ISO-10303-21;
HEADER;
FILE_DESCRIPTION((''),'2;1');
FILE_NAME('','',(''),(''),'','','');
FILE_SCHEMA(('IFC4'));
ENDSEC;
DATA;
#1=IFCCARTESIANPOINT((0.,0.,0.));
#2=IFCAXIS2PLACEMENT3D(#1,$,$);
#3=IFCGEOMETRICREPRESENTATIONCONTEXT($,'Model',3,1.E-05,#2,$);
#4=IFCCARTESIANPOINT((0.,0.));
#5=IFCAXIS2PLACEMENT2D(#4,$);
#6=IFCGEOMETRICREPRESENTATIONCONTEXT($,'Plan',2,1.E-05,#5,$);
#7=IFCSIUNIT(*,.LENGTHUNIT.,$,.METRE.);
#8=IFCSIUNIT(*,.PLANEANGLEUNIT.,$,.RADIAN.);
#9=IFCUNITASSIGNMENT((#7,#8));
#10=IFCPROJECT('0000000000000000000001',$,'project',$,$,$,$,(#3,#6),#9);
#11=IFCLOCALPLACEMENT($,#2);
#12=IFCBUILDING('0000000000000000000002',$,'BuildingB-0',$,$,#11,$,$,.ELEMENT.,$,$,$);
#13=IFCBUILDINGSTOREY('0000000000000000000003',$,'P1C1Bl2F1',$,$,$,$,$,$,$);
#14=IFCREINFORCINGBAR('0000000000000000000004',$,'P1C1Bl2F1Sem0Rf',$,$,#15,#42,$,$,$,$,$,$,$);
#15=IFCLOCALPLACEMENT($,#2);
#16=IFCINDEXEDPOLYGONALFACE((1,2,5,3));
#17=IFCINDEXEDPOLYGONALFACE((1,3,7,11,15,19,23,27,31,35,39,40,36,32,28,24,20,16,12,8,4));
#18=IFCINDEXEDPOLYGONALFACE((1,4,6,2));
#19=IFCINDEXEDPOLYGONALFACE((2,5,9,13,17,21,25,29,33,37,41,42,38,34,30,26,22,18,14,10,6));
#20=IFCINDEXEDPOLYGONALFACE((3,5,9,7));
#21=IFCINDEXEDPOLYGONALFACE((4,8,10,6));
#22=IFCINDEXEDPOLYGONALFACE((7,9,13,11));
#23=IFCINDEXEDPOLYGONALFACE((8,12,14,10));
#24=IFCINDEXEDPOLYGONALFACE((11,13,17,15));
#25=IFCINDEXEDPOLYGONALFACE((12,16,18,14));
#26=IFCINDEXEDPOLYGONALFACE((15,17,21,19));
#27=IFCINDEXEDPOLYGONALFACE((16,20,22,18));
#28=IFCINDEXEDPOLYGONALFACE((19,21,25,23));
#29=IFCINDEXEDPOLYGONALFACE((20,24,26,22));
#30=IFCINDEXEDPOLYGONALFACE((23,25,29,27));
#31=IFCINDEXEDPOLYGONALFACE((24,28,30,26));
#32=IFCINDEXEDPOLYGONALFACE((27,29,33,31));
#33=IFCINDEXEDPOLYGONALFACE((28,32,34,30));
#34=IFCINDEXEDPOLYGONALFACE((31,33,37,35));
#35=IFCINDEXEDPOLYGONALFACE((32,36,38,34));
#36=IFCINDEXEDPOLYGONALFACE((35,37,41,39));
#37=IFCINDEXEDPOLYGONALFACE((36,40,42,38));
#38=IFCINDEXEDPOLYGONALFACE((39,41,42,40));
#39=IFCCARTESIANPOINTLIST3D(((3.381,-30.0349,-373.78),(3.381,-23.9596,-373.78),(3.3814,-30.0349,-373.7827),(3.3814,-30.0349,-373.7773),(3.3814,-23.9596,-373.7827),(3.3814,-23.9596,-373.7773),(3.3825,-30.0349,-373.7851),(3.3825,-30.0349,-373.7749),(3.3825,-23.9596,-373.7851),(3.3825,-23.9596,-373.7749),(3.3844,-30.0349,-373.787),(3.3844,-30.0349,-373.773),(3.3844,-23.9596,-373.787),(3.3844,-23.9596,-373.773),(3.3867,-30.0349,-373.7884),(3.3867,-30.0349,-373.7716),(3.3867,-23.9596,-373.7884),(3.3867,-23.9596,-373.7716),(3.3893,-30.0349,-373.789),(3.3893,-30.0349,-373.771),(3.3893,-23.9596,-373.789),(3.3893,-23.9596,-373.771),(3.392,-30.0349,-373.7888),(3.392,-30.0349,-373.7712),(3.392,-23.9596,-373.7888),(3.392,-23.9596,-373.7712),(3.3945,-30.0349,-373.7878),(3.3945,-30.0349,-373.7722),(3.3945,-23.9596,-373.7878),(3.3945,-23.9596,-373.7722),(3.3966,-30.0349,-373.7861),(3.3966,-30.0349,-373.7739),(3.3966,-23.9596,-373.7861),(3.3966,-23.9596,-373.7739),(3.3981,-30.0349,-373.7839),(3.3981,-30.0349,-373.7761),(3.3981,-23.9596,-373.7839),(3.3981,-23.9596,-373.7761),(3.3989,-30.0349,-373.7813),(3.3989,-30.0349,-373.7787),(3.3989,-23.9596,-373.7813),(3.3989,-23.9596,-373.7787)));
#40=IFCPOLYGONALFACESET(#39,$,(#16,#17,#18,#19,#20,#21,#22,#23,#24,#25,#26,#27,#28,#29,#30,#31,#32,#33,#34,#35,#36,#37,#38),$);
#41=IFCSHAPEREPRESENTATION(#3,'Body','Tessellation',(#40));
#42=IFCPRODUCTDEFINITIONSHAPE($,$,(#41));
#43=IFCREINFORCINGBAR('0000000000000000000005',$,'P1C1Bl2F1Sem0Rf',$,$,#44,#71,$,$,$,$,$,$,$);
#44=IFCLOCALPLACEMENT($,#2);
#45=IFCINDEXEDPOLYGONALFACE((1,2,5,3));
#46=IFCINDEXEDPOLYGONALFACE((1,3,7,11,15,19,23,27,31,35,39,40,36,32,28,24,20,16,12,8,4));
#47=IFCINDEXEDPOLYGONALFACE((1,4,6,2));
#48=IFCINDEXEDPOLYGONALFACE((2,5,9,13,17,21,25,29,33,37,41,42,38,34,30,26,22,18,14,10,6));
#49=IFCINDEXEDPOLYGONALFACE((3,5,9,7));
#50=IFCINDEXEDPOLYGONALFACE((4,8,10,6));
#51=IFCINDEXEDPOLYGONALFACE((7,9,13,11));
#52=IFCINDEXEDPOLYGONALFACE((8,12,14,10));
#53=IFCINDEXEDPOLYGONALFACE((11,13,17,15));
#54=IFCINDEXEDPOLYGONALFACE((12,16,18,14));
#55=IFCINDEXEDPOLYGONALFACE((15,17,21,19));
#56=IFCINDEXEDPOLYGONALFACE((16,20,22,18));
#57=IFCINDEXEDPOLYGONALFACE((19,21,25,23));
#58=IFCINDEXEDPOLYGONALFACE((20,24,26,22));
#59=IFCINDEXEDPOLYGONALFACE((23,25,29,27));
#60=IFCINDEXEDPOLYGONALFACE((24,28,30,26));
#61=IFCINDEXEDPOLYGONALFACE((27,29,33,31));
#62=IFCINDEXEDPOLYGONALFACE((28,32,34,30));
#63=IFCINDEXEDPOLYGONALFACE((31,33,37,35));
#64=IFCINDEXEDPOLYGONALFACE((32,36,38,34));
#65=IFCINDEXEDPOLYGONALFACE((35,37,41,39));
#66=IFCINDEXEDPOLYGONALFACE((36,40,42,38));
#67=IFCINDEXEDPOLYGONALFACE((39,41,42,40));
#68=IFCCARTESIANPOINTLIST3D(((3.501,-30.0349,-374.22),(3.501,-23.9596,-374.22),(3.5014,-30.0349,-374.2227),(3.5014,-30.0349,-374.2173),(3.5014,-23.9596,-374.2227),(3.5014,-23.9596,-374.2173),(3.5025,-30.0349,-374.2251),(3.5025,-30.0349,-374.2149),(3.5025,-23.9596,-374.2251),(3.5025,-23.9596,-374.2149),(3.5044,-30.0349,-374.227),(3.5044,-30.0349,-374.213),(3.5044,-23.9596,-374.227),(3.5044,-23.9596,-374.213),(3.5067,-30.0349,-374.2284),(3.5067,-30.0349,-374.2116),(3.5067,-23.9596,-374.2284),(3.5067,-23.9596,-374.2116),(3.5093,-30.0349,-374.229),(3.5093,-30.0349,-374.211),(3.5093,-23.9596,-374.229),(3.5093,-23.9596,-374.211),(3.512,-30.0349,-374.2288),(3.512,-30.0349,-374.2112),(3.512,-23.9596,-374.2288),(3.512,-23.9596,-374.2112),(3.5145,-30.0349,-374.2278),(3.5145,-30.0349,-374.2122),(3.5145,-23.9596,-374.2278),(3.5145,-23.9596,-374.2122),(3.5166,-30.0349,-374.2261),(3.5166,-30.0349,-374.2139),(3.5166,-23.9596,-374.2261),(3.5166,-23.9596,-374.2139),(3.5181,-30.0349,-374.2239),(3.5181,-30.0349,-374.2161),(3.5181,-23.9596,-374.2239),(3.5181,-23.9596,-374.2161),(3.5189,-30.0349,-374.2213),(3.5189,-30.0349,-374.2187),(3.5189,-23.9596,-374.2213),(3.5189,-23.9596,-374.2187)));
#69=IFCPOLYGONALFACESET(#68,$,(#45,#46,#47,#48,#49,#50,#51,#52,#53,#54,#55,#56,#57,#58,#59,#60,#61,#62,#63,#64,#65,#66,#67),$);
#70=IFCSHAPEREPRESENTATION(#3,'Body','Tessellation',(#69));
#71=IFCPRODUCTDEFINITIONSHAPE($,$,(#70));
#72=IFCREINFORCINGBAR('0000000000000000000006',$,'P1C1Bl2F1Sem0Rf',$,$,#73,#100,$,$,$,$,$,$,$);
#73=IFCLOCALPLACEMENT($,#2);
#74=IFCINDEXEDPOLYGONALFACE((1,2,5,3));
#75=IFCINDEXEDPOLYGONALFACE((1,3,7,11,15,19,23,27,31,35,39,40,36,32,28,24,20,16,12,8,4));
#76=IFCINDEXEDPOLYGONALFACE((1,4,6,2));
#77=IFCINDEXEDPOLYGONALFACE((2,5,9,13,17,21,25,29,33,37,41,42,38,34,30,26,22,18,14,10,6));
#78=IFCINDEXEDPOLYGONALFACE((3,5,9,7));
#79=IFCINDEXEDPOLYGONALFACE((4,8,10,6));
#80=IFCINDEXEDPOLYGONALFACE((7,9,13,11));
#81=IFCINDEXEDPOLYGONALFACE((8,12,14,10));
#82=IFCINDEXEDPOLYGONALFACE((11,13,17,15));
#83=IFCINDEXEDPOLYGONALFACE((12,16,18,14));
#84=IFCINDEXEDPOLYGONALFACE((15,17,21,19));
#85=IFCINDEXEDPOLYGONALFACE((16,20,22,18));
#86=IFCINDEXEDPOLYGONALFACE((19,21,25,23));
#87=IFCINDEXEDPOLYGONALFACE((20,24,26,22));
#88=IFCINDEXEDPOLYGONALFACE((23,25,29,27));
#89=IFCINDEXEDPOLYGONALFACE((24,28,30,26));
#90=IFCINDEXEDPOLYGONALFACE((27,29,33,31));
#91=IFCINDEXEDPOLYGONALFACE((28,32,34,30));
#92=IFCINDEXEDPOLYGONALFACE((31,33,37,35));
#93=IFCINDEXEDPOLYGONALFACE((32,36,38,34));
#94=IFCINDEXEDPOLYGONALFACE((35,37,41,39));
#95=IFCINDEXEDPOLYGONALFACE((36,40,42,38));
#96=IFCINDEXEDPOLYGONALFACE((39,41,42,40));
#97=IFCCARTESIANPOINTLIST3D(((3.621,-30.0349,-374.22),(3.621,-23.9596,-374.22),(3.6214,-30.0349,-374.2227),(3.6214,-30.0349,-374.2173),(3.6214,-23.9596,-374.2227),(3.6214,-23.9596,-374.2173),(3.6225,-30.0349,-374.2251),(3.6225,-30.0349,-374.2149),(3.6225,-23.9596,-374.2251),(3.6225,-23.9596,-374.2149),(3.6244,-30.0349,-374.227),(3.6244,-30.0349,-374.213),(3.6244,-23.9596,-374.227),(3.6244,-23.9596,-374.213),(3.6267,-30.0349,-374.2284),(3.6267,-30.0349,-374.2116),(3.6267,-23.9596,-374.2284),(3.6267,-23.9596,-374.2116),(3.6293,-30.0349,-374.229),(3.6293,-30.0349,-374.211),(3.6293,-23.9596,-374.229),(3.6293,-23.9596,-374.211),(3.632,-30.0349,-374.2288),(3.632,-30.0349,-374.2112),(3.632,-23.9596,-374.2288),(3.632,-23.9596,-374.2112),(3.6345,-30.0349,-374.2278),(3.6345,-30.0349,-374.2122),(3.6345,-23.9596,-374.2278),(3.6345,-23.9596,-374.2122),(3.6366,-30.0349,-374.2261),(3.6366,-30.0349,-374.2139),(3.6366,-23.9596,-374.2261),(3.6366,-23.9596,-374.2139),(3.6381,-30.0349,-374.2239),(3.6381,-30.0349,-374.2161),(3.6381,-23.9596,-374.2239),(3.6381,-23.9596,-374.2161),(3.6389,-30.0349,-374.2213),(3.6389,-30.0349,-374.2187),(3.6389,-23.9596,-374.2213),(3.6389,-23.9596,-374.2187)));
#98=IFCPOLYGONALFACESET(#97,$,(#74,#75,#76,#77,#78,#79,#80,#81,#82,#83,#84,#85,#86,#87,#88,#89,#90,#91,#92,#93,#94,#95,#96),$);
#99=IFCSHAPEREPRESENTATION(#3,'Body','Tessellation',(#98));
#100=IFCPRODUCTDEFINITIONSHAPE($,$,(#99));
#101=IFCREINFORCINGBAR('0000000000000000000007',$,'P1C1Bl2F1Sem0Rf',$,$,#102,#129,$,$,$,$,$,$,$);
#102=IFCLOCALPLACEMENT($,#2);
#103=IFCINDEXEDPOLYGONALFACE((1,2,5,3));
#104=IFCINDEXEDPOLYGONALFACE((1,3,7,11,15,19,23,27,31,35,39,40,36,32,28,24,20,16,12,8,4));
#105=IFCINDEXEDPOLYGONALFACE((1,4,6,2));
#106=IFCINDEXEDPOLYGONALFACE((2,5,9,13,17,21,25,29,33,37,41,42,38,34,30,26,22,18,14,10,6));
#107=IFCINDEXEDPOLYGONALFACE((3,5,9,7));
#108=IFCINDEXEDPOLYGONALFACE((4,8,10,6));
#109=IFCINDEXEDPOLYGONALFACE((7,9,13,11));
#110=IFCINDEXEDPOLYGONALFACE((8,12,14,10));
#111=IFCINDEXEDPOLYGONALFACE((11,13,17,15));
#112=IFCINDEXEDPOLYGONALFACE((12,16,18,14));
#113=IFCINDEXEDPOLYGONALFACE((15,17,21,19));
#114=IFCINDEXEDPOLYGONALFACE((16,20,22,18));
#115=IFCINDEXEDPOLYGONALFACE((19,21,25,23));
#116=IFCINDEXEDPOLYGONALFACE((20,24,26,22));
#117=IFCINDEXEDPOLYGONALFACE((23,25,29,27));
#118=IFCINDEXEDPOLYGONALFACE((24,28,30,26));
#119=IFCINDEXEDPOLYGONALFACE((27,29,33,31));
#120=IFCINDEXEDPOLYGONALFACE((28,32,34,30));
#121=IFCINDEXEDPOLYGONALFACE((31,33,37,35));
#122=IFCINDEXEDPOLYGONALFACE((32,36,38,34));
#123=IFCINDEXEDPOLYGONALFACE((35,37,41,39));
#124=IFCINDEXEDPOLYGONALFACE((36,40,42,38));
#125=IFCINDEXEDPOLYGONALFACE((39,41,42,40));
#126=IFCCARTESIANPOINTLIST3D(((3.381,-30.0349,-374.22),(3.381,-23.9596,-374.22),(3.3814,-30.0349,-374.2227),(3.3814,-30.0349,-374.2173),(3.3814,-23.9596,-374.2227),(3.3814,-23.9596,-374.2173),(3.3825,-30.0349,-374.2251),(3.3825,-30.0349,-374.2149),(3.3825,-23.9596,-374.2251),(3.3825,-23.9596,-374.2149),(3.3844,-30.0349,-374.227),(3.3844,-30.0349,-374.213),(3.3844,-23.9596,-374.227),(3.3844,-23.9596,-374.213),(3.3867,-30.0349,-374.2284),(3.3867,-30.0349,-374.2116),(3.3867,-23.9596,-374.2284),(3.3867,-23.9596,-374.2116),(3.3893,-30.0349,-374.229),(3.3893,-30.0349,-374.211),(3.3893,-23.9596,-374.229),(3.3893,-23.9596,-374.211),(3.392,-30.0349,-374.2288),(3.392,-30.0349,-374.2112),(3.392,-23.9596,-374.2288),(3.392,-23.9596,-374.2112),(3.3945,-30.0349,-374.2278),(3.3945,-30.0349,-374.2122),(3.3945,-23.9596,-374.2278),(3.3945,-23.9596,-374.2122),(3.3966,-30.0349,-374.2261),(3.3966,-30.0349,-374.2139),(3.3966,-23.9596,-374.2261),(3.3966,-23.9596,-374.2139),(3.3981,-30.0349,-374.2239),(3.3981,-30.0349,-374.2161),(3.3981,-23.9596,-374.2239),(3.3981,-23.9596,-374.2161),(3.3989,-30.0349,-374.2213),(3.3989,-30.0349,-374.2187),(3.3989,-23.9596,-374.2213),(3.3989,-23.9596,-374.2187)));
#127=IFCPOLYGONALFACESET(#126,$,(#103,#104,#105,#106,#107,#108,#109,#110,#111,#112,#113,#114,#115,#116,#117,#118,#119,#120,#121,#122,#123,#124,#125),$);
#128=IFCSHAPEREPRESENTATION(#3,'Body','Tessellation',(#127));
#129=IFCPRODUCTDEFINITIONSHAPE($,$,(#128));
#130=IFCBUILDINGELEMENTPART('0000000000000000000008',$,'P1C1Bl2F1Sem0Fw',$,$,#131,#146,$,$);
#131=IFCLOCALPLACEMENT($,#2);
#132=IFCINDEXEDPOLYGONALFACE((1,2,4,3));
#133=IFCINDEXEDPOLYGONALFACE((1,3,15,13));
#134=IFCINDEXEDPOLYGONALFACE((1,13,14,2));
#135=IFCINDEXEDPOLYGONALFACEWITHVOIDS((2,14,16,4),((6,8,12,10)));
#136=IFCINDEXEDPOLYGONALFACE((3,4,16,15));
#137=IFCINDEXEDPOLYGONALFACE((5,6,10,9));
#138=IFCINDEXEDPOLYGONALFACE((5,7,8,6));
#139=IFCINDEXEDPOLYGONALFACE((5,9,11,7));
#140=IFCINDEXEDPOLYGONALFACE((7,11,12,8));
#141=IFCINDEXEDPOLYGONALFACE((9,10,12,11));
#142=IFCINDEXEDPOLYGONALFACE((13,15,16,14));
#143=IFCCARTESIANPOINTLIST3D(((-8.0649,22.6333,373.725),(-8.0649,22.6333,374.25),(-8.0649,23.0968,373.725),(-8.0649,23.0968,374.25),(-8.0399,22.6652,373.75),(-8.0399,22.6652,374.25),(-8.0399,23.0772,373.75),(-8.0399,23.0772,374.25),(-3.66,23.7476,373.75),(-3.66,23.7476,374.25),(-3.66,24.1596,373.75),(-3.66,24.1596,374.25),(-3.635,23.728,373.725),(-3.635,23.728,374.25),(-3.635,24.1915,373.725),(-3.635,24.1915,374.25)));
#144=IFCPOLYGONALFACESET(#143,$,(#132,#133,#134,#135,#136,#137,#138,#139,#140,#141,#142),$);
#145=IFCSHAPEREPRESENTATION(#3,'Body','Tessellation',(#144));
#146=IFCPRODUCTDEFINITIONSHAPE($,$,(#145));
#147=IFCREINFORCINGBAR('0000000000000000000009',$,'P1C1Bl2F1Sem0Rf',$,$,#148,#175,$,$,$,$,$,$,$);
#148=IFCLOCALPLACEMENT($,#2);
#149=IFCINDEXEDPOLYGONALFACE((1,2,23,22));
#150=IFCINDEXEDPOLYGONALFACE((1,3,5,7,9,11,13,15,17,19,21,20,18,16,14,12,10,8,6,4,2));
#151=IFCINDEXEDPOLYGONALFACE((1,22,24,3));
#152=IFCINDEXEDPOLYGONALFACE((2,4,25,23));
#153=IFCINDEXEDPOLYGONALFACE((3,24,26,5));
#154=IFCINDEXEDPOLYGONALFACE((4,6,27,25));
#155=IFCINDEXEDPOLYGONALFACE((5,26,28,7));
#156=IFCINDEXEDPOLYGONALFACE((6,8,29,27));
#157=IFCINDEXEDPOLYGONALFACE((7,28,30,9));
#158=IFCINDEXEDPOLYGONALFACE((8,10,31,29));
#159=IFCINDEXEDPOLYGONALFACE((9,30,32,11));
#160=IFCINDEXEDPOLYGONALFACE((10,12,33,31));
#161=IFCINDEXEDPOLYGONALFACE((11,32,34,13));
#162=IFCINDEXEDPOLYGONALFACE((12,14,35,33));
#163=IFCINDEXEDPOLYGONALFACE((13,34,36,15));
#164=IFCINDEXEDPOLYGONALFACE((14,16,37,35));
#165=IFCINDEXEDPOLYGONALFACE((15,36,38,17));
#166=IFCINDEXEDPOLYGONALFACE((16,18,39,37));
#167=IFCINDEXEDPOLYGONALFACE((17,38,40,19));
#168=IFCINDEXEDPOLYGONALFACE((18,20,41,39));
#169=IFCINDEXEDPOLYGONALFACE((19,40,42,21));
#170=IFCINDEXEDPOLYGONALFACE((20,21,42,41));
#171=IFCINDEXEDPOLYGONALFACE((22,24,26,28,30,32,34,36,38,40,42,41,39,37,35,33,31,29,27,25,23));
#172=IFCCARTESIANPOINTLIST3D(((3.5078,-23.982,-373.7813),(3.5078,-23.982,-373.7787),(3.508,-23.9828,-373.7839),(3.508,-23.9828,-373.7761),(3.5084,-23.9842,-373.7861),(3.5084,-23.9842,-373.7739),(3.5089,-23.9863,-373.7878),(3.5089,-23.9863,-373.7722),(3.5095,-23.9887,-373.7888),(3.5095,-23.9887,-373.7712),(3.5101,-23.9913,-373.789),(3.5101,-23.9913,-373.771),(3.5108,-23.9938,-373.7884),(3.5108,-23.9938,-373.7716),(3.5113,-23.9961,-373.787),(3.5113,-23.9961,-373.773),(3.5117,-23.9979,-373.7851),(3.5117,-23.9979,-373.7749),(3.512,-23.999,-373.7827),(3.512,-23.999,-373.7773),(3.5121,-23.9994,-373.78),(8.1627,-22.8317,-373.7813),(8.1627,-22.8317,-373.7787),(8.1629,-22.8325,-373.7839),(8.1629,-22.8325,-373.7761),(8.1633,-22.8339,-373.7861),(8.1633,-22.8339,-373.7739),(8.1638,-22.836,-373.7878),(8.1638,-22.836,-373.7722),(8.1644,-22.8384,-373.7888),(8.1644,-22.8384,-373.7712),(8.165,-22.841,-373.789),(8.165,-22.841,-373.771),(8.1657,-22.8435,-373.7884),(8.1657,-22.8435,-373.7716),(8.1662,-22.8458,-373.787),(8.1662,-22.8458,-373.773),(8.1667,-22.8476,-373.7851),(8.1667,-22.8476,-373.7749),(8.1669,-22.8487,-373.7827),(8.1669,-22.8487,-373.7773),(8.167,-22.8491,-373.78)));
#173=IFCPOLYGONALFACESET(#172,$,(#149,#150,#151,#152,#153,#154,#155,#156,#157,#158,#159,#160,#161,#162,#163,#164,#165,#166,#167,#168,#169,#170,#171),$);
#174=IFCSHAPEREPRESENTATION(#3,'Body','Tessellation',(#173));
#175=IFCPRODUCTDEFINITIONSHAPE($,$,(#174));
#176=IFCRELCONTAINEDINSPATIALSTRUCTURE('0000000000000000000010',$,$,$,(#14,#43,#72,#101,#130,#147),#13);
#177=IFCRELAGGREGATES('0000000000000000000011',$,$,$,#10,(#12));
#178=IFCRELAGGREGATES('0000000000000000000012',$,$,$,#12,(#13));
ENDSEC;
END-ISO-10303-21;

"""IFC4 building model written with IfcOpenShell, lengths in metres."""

from ifc_helpers import new_model, entity, si_unit, origin, origin_2d, place, context, project, spatial, polyline, outline, extrude, element, save


model = new_model("IFC4")

# Units and contexts
model_context = context("Model", 3, precision=1e-05, world=origin())
plan_context = context("Plan", 2, precision=1e-05, world=origin_2d())
ifc_project = project(units=[si_unit("LENGTHUNIT", "METRE"), si_unit("PLANEANGLEUNIT", "RADIAN")], contexts=[model_context, plan_context])

# Building, storey
building_placement = place(None, origin())
building = spatial("IfcBuilding", under=ifc_project, at=building_placement, Name="BuildingB-0", CompositionType="ELEMENT")
storey = spatial("IfcBuildingStorey", under=building, Name="P1C1Bl2F1")

# Reinforcing bars
element("IfcReinforcingBar", 1, inside=storey, Name="P1C1Bl2F1Sem0Rf", context=model_context, shape_type="SweptSolid", body=[
    entity("IfcSurfaceCurveSweptAreaSolid", entity("IfcCircleProfileDef", "AREA", None, None, 0.009), None, entity("IfcPolyline", [entity("IfcCartesianPoint", [-3.39, 30.0349, 373.78]), entity("IfcCartesianPoint", [-3.39, 23.9596, 373.78])]), None, None, entity("IfcPlane", entity("IfcAxis2Placement3D", entity("IfcCartesianPoint", [-3.39, 30.0349, 373.78]), entity("IfcDirection", [0.0, 0.0, 1.0]), entity("IfcDirection", [1.0, 0.0, 0.0])))),
])
element("IfcReinforcingBar", 2, inside=storey, Name="P1C1Bl2F1Sem0Rf", context=model_context, shape_type="SweptSolid", body=[
    entity("IfcSurfaceCurveSweptAreaSolid", entity("IfcCircleProfileDef", "AREA", None, None, 0.009), None, entity("IfcPolyline", [entity("IfcCartesianPoint", [-3.51, 30.0349, 374.22]), entity("IfcCartesianPoint", [-3.51, 23.9596, 374.22])]), None, None, entity("IfcPlane", entity("IfcAxis2Placement3D", entity("IfcCartesianPoint", [-3.51, 30.0349, 374.22]), entity("IfcDirection", [0.0, 0.0, 1.0]), entity("IfcDirection", [1.0, 0.0, 0.0])))),
])
element("IfcReinforcingBar", 3, inside=storey, Name="P1C1Bl2F1Sem0Rf", context=model_context, shape_type="SweptSolid", body=[
    entity("IfcSurfaceCurveSweptAreaSolid", entity("IfcCircleProfileDef", "AREA", None, None, 0.009), None, entity("IfcPolyline", [entity("IfcCartesianPoint", [-3.63, 30.0349, 374.22]), entity("IfcCartesianPoint", [-3.63, 23.9596, 374.22])]), None, None, entity("IfcPlane", entity("IfcAxis2Placement3D", entity("IfcCartesianPoint", [-3.63, 30.0349, 374.22]), entity("IfcDirection", [0.0, 0.0, 1.0]), entity("IfcDirection", [1.0, 0.0, 0.0])))),
])
element("IfcReinforcingBar", 4, inside=storey, Name="P1C1Bl2F1Sem0Rf", context=model_context, shape_type="SweptSolid", body=[
    entity("IfcSurfaceCurveSweptAreaSolid", entity("IfcCircleProfileDef", "AREA", None, None, 0.009), None, entity("IfcPolyline", [entity("IfcCartesianPoint", [-3.39, 30.0349, 374.22]), entity("IfcCartesianPoint", [-3.39, 23.9596, 374.22])]), None, None, entity("IfcPlane", entity("IfcAxis2Placement3D", entity("IfcCartesianPoint", [-3.39, 30.0349, 374.22]), entity("IfcDirection", [0.0, 0.0, 1.0]), entity("IfcDirection", [1.0, 0.0, 0.0])))),
])

# Building element part, opening
building_element_part_1 = element("IfcBuildingElementPart", 5, inside=storey, Name="P1C1Bl2F1Sem0Fw", context=model_context, shape_type="SweptSolid", body=[
    extrude(outline(polyline([(-3.635, 24.1915, 373.725), (-3.635, 23.728, 373.725), (-8.0649, 22.6333, 373.725), (-8.0649, 23.0968, 373.725), (-3.635, 24.1915, 373.725)])), None, (0.0, 0.0, 1.0), 0.525),
])
element("IfcOpeningElement", 6, inside=storey, cuts=building_element_part_1, context=model_context, shape_type="SweptSolid", body=[
    extrude(outline(polyline([(-3.66, 24.1596, 373.75), (-3.66, 23.7476, 373.75), (-8.0399, 22.6652, 373.75), (-8.0399, 23.0772, 373.75), (-3.66, 24.1596, 373.75)])), None, (0.0, 0.0, 1.0), 0.5),
])

# Reinforcing bar
element("IfcReinforcingBar", 7, inside=storey, Name="P1C1Bl2F1Sem0Rf", context=model_context, shape_type="SweptSolid", body=[
    entity("IfcSurfaceCurveSweptAreaSolid", entity("IfcCircleProfileDef", "AREA", None, None, 0.009), None, entity("IfcPolyline", [entity("IfcCartesianPoint", [-3.51, 23.9907, 373.78]), entity("IfcCartesianPoint", [-8.1649, 22.8403, 373.78])]), None, None, entity("IfcPlane", entity("IfcAxis2Placement3D", entity("IfcCartesianPoint", [-3.51, 23.9907, 373.78]), entity("IfcDirection", [0.0, 0.0, 1.0]), entity("IfcDirection", [1.0, 0.0, 0.0])))),
])

save(model, "model.ifc")
